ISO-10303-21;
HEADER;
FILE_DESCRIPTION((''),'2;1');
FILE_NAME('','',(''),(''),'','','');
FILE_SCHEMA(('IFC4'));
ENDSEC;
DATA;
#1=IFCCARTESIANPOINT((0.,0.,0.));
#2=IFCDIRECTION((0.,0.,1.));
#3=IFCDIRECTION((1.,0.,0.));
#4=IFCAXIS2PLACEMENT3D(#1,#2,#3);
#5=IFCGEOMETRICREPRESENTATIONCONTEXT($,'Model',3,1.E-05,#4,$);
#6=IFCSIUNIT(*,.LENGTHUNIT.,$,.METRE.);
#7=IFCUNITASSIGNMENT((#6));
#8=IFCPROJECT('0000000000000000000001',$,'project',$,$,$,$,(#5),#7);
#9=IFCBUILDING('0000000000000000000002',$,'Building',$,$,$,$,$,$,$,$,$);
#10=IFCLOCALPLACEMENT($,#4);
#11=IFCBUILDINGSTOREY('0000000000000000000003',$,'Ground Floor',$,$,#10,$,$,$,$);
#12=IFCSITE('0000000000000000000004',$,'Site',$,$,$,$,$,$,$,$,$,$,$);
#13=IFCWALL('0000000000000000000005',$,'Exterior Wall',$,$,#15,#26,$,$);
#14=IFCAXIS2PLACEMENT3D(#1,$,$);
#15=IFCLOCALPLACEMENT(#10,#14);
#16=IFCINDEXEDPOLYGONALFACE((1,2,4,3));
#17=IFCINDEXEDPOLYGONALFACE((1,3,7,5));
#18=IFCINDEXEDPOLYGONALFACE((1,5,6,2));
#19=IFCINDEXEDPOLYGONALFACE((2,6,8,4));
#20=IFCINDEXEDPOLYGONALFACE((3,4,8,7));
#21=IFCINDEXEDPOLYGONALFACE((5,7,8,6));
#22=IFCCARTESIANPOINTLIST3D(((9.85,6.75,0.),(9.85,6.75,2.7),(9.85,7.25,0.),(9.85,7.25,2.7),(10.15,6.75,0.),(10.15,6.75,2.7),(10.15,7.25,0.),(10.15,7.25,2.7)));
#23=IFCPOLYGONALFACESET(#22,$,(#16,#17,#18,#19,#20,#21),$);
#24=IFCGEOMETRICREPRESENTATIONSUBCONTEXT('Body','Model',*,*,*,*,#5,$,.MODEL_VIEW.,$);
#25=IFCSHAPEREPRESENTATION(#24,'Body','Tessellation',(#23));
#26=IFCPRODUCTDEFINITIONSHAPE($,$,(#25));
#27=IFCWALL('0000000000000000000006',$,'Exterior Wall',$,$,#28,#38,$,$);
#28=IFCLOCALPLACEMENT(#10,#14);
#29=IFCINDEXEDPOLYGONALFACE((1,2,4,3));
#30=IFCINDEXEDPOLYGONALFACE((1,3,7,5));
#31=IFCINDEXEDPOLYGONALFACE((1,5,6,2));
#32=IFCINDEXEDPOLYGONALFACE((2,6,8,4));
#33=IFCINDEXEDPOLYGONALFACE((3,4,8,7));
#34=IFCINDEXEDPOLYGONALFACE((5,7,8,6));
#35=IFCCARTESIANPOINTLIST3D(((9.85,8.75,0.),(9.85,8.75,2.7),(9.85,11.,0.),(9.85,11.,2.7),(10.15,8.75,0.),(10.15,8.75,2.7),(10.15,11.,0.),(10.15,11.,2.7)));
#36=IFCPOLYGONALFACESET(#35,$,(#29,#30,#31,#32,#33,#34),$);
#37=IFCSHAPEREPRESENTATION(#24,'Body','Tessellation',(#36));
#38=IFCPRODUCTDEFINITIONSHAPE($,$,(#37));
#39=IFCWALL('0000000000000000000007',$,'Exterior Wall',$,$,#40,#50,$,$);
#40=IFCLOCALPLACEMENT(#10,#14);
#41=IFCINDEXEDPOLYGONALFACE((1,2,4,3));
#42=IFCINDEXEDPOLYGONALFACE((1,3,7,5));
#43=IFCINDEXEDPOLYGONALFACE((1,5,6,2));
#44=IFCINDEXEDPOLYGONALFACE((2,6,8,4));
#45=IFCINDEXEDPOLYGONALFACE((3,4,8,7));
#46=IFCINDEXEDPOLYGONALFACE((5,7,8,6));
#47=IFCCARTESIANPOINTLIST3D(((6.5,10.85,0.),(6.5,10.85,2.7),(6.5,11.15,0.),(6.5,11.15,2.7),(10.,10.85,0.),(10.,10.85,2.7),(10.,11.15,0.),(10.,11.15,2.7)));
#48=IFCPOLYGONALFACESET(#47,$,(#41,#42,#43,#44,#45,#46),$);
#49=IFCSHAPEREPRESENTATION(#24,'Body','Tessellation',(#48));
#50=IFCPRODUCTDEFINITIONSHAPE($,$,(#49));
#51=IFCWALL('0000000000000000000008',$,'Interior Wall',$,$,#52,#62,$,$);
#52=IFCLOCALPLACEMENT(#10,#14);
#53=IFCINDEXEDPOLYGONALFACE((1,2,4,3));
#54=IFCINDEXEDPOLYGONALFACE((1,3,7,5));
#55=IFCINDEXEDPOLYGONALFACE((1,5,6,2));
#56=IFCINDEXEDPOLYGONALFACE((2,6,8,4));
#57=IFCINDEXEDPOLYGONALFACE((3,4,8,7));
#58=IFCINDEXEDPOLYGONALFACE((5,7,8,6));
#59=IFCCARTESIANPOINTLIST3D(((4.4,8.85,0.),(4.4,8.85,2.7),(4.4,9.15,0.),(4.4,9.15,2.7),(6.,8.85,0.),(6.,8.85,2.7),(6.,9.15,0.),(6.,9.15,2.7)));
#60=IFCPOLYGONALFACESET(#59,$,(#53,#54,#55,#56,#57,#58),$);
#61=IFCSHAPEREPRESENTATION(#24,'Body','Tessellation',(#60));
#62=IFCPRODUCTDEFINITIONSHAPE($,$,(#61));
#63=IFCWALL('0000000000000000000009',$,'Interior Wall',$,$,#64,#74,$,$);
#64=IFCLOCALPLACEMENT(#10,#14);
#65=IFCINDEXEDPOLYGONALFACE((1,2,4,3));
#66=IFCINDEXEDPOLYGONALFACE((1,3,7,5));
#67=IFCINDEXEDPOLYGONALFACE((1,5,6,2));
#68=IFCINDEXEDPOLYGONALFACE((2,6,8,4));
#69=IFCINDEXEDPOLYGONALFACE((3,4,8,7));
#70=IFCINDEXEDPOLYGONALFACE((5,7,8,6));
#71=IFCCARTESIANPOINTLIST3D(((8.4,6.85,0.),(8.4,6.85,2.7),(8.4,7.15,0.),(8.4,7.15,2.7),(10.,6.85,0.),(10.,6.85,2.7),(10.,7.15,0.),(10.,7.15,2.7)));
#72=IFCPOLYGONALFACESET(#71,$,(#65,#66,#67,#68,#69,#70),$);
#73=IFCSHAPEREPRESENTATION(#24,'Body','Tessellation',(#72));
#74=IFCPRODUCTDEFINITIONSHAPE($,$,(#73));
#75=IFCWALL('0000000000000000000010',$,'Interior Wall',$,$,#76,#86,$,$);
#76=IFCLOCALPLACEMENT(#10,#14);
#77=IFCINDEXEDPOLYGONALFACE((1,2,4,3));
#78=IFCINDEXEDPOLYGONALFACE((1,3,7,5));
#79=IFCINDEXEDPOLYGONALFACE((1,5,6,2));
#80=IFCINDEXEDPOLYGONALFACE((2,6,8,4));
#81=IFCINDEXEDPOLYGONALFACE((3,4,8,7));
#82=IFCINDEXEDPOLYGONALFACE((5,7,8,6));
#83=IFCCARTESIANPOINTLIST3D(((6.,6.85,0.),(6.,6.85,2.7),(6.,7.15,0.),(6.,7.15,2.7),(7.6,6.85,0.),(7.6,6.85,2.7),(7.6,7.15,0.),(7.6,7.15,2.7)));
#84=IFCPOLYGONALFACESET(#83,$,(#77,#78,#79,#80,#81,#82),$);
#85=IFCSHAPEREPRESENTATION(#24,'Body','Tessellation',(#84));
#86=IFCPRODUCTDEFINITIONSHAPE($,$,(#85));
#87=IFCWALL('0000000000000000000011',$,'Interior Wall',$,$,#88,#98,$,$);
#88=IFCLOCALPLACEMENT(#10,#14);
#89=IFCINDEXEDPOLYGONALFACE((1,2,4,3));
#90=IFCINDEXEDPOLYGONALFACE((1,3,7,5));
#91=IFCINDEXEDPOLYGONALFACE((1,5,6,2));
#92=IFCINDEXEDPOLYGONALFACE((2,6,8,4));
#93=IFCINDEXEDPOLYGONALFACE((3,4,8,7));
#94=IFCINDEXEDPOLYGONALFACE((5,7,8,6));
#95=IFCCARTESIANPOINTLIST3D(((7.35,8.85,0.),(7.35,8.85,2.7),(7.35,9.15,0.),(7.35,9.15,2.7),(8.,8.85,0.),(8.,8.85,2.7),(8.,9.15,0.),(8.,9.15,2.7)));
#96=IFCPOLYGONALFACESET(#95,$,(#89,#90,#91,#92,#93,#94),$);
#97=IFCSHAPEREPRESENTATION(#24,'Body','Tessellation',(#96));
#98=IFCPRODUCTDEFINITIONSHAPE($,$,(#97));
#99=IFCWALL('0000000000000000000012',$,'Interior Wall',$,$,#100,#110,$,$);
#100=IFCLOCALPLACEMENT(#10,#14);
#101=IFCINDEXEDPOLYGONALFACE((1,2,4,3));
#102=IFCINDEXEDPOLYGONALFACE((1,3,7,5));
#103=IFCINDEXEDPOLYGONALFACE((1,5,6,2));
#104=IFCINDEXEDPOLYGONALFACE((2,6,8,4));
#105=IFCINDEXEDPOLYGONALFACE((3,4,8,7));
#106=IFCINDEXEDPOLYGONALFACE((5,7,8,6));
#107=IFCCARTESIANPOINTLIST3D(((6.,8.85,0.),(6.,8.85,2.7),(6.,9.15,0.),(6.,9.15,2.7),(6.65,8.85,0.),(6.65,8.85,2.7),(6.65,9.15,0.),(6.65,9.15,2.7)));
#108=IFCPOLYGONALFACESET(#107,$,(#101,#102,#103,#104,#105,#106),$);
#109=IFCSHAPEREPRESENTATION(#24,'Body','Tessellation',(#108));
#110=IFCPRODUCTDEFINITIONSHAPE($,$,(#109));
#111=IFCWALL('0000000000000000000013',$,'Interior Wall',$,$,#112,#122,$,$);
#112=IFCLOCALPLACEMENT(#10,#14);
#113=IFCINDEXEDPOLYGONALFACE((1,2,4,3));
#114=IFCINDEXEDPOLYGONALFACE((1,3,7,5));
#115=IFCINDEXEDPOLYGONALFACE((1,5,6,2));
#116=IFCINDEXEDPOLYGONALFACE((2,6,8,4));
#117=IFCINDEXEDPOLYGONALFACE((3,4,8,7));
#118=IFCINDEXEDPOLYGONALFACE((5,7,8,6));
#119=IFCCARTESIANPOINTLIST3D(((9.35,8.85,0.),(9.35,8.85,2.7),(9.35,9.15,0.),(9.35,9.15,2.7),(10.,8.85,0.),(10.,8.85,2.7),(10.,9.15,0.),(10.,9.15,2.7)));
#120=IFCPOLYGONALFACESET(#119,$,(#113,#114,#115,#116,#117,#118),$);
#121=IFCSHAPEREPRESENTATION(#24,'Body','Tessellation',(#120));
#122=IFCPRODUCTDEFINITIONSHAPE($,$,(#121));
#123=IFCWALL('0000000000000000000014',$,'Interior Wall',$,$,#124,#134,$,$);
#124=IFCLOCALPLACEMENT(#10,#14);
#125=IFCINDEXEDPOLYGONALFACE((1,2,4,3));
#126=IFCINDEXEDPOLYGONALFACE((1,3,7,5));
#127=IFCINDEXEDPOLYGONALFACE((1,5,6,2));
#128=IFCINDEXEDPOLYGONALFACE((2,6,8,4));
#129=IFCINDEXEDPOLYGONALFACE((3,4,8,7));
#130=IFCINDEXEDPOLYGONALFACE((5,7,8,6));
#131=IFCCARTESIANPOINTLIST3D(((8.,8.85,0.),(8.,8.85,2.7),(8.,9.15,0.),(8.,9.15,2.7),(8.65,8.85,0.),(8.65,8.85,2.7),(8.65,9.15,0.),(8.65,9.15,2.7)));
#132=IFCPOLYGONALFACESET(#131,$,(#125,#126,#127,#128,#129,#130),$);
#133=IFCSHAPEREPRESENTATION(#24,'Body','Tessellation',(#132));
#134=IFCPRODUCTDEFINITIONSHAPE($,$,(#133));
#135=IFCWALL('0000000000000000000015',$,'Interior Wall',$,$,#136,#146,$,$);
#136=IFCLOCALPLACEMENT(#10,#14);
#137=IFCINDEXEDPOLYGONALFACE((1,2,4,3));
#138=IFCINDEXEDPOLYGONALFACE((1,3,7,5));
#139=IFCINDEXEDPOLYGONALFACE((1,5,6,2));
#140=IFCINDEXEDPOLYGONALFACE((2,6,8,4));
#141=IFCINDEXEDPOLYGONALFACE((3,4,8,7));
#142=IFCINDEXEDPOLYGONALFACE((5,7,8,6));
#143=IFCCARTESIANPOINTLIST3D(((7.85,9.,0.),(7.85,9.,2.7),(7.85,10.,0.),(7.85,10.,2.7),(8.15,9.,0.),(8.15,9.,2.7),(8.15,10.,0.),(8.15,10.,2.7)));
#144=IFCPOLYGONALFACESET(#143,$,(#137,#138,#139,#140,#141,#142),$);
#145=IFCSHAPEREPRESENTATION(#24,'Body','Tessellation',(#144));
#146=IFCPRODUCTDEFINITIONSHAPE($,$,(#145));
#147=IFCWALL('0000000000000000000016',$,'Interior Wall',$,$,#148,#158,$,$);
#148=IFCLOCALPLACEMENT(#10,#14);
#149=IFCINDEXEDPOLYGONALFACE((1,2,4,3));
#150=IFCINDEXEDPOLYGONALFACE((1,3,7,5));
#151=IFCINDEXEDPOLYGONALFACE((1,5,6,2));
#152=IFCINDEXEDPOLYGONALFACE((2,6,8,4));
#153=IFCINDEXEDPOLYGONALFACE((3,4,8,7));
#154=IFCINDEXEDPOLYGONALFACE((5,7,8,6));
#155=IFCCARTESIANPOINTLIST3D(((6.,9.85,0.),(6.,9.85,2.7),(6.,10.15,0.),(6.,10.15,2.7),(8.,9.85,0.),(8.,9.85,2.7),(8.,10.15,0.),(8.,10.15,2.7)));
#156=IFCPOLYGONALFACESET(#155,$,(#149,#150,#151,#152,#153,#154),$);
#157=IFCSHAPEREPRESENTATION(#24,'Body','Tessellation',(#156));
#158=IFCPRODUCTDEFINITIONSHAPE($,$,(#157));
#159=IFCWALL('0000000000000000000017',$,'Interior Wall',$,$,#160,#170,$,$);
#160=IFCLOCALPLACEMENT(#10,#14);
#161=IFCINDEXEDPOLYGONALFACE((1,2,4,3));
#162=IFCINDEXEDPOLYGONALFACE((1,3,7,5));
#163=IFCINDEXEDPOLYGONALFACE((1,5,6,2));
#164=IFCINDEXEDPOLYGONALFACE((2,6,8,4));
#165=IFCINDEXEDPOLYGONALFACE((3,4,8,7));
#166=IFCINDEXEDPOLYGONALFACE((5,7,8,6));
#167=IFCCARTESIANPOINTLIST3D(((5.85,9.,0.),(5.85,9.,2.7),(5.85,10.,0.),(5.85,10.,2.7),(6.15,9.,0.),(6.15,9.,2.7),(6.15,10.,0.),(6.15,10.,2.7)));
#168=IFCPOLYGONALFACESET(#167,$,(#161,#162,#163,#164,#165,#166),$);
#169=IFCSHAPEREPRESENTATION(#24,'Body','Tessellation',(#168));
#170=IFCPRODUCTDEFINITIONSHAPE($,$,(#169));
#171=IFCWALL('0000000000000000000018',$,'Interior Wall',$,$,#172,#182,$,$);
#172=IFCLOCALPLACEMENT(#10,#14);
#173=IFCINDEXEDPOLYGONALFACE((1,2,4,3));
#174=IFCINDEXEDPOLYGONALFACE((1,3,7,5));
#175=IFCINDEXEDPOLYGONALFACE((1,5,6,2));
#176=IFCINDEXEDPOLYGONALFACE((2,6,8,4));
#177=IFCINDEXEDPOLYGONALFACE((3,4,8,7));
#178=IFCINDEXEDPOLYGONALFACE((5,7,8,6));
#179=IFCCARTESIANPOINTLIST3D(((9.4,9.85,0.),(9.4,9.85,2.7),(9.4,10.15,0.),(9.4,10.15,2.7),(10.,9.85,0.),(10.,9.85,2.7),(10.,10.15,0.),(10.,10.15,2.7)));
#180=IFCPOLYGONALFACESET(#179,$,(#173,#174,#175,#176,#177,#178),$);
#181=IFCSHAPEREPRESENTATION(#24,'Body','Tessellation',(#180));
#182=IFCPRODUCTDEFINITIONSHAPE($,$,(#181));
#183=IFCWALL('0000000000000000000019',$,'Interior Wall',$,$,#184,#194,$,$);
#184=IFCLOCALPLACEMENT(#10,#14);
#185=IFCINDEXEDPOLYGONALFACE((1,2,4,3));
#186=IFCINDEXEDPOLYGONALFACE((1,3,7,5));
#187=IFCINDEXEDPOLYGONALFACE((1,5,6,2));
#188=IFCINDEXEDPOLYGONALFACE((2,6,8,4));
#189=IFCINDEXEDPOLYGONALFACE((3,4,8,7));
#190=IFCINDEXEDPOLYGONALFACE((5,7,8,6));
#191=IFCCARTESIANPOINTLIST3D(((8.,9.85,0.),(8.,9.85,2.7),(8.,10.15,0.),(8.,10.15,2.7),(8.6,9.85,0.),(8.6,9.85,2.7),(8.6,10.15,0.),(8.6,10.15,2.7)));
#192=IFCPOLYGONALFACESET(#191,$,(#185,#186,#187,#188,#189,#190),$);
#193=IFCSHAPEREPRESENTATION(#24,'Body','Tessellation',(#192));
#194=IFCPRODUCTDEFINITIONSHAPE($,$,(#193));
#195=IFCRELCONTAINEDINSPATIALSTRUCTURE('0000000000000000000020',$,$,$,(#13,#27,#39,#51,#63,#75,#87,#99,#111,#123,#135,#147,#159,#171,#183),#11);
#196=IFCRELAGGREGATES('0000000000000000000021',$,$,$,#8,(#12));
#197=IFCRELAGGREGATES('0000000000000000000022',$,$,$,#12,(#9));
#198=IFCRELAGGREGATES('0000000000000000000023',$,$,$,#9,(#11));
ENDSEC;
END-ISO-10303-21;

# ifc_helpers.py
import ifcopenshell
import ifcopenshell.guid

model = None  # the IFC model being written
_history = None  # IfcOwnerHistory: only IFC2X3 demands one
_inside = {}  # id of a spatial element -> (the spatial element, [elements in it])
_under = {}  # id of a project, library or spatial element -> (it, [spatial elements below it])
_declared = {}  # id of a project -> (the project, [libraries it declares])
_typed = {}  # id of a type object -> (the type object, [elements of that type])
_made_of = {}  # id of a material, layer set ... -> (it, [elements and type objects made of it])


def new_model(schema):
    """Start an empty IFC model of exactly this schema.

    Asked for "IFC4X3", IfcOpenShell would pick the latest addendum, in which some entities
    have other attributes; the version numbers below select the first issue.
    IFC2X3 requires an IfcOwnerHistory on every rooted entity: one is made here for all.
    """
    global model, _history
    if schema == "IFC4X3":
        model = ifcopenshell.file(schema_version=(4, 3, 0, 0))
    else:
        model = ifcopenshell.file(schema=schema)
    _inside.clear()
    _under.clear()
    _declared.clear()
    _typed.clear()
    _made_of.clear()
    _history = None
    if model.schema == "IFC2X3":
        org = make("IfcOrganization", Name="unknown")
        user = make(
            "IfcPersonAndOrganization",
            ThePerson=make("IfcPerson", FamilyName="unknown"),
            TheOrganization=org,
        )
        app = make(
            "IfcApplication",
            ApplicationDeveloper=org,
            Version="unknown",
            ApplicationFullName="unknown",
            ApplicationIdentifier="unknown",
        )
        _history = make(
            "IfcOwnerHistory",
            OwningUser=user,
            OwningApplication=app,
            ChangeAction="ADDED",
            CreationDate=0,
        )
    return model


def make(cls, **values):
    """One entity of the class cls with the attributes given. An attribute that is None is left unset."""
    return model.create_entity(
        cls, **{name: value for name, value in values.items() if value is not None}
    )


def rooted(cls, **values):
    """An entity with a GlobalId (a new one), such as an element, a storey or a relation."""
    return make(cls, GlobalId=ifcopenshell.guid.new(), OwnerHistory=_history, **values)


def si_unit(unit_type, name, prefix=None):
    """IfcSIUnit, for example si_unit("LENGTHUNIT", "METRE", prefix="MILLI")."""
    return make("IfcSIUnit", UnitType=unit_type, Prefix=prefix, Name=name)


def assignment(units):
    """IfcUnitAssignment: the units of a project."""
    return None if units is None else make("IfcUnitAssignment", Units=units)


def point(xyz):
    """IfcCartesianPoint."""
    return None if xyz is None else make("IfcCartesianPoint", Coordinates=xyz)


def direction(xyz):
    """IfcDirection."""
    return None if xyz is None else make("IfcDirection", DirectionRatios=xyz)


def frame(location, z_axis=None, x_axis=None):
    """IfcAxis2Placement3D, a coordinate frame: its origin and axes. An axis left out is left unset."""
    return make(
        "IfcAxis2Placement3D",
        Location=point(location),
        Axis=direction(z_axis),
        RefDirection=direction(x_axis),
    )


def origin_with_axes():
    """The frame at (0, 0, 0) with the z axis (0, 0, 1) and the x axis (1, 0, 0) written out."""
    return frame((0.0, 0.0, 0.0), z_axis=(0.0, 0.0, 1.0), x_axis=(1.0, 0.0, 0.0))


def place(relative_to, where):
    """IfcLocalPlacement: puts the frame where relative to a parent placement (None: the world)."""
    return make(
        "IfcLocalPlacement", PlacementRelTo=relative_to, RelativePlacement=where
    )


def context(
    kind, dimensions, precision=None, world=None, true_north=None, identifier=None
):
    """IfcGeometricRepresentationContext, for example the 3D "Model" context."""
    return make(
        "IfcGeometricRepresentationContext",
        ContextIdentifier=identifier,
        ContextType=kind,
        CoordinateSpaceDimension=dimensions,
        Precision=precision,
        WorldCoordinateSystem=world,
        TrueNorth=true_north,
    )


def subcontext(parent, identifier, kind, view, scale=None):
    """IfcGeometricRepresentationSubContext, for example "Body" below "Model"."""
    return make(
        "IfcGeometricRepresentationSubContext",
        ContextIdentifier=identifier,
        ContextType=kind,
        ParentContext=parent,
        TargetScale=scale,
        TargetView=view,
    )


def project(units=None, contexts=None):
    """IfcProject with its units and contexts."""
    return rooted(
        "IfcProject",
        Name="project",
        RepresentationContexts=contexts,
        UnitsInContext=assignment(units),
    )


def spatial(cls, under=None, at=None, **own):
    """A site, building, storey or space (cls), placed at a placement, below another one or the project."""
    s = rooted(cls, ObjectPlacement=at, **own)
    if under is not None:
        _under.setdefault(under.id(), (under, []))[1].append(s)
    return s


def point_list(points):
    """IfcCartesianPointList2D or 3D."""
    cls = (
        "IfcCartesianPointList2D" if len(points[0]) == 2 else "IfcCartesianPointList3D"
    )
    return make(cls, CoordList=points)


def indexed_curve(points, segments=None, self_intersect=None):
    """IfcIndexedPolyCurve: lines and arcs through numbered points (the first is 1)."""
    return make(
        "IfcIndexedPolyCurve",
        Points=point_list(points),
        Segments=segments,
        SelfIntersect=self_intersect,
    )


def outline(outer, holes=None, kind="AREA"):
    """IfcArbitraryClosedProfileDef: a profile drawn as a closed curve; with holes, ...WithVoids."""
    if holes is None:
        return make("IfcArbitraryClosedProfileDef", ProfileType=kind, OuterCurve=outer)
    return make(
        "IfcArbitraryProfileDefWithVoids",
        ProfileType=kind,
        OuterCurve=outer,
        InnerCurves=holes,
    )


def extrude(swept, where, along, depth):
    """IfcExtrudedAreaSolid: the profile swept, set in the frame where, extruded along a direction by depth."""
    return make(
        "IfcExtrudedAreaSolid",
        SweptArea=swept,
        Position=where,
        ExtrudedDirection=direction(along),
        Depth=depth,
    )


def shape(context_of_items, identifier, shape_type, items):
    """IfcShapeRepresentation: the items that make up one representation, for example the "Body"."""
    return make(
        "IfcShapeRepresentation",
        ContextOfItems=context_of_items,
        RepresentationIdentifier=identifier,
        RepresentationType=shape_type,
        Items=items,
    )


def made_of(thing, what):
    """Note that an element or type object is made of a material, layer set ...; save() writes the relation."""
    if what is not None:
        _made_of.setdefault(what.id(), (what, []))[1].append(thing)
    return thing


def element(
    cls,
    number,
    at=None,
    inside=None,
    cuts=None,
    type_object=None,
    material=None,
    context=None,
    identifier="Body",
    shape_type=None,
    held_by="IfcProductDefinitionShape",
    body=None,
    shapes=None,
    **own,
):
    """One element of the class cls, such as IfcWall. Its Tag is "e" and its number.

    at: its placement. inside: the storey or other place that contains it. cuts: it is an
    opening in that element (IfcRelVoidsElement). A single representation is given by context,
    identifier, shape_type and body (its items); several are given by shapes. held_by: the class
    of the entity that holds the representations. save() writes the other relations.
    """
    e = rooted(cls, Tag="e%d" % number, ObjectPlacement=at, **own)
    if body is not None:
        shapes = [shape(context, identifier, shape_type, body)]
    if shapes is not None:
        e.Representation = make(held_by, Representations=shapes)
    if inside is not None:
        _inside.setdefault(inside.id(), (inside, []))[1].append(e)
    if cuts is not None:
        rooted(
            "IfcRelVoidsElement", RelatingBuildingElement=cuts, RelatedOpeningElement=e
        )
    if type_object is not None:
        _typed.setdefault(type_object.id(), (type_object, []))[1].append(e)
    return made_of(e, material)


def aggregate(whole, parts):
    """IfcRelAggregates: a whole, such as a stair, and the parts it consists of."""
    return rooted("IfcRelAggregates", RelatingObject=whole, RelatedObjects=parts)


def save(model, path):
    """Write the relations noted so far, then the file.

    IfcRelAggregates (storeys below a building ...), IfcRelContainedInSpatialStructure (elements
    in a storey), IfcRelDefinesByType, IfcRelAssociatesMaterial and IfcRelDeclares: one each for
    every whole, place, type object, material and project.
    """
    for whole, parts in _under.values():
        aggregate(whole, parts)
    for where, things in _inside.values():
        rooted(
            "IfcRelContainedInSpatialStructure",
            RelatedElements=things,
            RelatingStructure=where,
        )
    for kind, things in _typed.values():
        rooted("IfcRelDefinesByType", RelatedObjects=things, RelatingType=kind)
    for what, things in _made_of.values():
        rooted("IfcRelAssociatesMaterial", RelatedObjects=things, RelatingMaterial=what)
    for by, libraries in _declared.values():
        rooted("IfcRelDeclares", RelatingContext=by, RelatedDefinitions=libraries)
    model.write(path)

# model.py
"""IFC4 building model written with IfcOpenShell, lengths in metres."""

from ifc_helpers import new_model, si_unit, frame, origin_with_axes, place, context, subcontext, project, spatial, indexed_curve, outline, extrude, element, save


model = new_model("IFC4")

# Units and contexts
model_context = context("Model", 3, precision=1e-05, world=origin_with_axes())
body_context = subcontext(model_context, "Body", "Model", "MODEL_VIEW")
ifc_project = project(units=[si_unit("LENGTHUNIT", "METRE")], contexts=[model_context])

# Site, building, storey
site = spatial("IfcSite", under=ifc_project, Name="Site")
building = spatial("IfcBuilding", under=site, Name="Building")
storey_placement = place(None, origin_with_axes())
storey = spatial("IfcBuildingStorey", under=building, at=storey_placement, Name="Ground Floor")

# Walls
wall_1_placement = place(storey_placement, frame((10.0, 6.75, 0.0), z_axis=(0.0, 0.0, 1.0), x_axis=(0.0, 1.0, 0.0)))
element("IfcWall", 1, at=wall_1_placement, inside=storey, Name="Exterior Wall", context=body_context, shape_type="SweptSolid", body=[
    extrude(outline(indexed_curve([(0.0, 0.0), (0.0, 0.3), (0.5, 0.3), (0.5, 0.0), (0.0, 0.0)], self_intersect=False)), frame((0.0, -0.15, 0.0), z_axis=(0.0, 0.0, 1.0), x_axis=(1.0, 0.0, 0.0)), (0.0, 0.0, 1.0), 2.7),
])
wall_2_placement = place(storey_placement, frame((10.0, 8.75, 0.0), z_axis=(0.0, 0.0, 1.0), x_axis=(0.0, 1.0, 0.0)))
element("IfcWall", 2, at=wall_2_placement, inside=storey, Name="Exterior Wall", context=body_context, shape_type="SweptSolid", body=[
    extrude(outline(indexed_curve([(0.0, 0.0), (0.0, 0.3), (2.25, 0.3), (2.25, 0.0), (0.0, 0.0)], self_intersect=False)), frame((0.0, -0.15, 0.0), z_axis=(0.0, 0.0, 1.0), x_axis=(1.0, 0.0, 0.0)), (0.0, 0.0, 1.0), 2.7),
])
wall_3_placement = place(storey_placement, frame((10.0, 11.0, 0.0), z_axis=(0.0, 0.0, 1.0), x_axis=(-1.0, 0.0, 0.0)))
element("IfcWall", 3, at=wall_3_placement, inside=storey, Name="Exterior Wall", context=body_context, shape_type="SweptSolid", body=[
    extrude(outline(indexed_curve([(0.0, 0.0), (0.0, 0.3), (3.5, 0.3), (3.5, 0.0), (0.0, 0.0)], self_intersect=False)), frame((0.0, -0.15, 0.0), z_axis=(0.0, 0.0, 1.0), x_axis=(1.0, 0.0, 0.0)), (0.0, 0.0, 1.0), 2.7),
])
for number, where, z_axis, x_axis, name in (
    (4, (6.0, 9.0, 0.0), (0.0, 0.0, 1.0), (-1.0, 0.0, 0.0), "Interior Wall"),
    (5, (10.0, 7.0, 0.0), (0.0, 0.0, 1.0), (-1.0, 0.0, 0.0), "Interior Wall"),
    (6, (7.6, 7.0, 0.0), (0.0, 0.0, 1.0), (-1.0, 0.0, 0.0), "Interior Wall"),
):
    element("IfcWall", number, at=place(storey_placement, frame(where, z_axis=z_axis, x_axis=x_axis)), inside=storey, Name=name, context=body_context, shape_type="SweptSolid", body=[
        extrude(outline(indexed_curve([(0.0, 0.0), (0.0, 0.3), (1.6, 0.3), (1.6, 0.0), (0.0, 0.0)], self_intersect=False)), frame((0.0, -0.15, 0.0), z_axis=(0.0, 0.0, 1.0), x_axis=(1.0, 0.0, 0.0)), (0.0, 0.0, 1.0), 2.7),
    ])
for number, where, z_axis, x_axis, name in (
    (7, (8.0, 9.0, 0.0), (0.0, 0.0, 1.0), (-1.0, 0.0, 0.0), "Interior Wall"),
    (8, (6.65, 9.0, 0.0), (0.0, 0.0, 1.0), (-1.0, 0.0, 0.0), "Interior Wall"),
    (9, (10.0, 9.0, 0.0), (0.0, 0.0, 1.0), (-1.0, 0.0, 0.0), "Interior Wall"),
    (10, (8.65, 9.0, 0.0), (0.0, 0.0, 1.0), (-1.0, 0.0, 0.0), "Interior Wall"),
):
    element("IfcWall", number, at=place(storey_placement, frame(where, z_axis=z_axis, x_axis=x_axis)), inside=storey, Name=name, context=body_context, shape_type="SweptSolid", body=[
        extrude(outline(indexed_curve([(0.0, 0.0), (0.0, 0.3), (0.65, 0.3), (0.65, 0.0), (0.0, 0.0)], self_intersect=False)), frame((0.0, -0.15, 0.0), z_axis=(0.0, 0.0, 1.0), x_axis=(1.0, 0.0, 0.0)), (0.0, 0.0, 1.0), 2.7),
    ])
wall_4_placement = place(storey_placement, frame((8.0, 9.0, 0.0), z_axis=(0.0, 0.0, 1.0), x_axis=(0.0, 1.0, 0.0)))
element("IfcWall", 11, at=wall_4_placement, inside=storey, Name="Interior Wall", context=body_context, shape_type="SweptSolid", body=[
    extrude(outline(indexed_curve([(0.0, 0.0), (0.0, 0.3), (1.0, 0.3), (1.0, 0.0), (0.0, 0.0)], self_intersect=False)), frame((0.0, -0.15, 0.0), z_axis=(0.0, 0.0, 1.0), x_axis=(1.0, 0.0, 0.0)), (0.0, 0.0, 1.0), 2.7),
])
wall_5_placement = place(storey_placement, frame((8.0, 10.0, 0.0), z_axis=(0.0, 0.0, 1.0), x_axis=(-1.0, 0.0, 0.0)))
element("IfcWall", 12, at=wall_5_placement, inside=storey, Name="Interior Wall", context=body_context, shape_type="SweptSolid", body=[
    extrude(outline(indexed_curve([(0.0, 0.0), (0.0, 0.3), (2.0, 0.3), (2.0, 0.0), (0.0, 0.0)], self_intersect=False)), frame((0.0, -0.15, 0.0), z_axis=(0.0, 0.0, 1.0), x_axis=(1.0, 0.0, 0.0)), (0.0, 0.0, 1.0), 2.7),
])
wall_6_placement = place(storey_placement, frame((6.0, 10.0, 0.0), z_axis=(0.0, 0.0, 1.0), x_axis=(0.0, -1.0, 0.0)))
element("IfcWall", 13, at=wall_6_placement, inside=storey, Name="Interior Wall", context=body_context, shape_type="SweptSolid", body=[
    extrude(outline(indexed_curve([(0.0, 0.0), (0.0, 0.3), (1.0, 0.3), (1.0, 0.0), (0.0, 0.0)], self_intersect=False)), frame((0.0, -0.15, 0.0), z_axis=(0.0, 0.0, 1.0), x_axis=(1.0, 0.0, 0.0)), (0.0, 0.0, 1.0), 2.7),
])
for number, where, z_axis, x_axis, name in (
    (14, (10.0, 10.0, 0.0), (0.0, 0.0, 1.0), (-1.0, 0.0, 0.0), "Interior Wall"),
    (15, (8.6, 10.0, 0.0), (0.0, 0.0, 1.0), (-1.0, 0.0, 0.0), "Interior Wall"),
):
    element("IfcWall", number, at=place(storey_placement, frame(where, z_axis=z_axis, x_axis=x_axis)), inside=storey, Name=name, context=body_context, shape_type="SweptSolid", body=[
        extrude(outline(indexed_curve([(0.0, 0.0), (0.0, 0.3), (0.6, 0.3), (0.6, 0.0), (0.0, 0.0)], self_intersect=False)), frame((0.0, -0.15, 0.0), z_axis=(0.0, 0.0, 1.0), x_axis=(1.0, 0.0, 0.0)), (0.0, 0.0, 1.0), 2.7),
    ])

save(model, "model.ifc")
